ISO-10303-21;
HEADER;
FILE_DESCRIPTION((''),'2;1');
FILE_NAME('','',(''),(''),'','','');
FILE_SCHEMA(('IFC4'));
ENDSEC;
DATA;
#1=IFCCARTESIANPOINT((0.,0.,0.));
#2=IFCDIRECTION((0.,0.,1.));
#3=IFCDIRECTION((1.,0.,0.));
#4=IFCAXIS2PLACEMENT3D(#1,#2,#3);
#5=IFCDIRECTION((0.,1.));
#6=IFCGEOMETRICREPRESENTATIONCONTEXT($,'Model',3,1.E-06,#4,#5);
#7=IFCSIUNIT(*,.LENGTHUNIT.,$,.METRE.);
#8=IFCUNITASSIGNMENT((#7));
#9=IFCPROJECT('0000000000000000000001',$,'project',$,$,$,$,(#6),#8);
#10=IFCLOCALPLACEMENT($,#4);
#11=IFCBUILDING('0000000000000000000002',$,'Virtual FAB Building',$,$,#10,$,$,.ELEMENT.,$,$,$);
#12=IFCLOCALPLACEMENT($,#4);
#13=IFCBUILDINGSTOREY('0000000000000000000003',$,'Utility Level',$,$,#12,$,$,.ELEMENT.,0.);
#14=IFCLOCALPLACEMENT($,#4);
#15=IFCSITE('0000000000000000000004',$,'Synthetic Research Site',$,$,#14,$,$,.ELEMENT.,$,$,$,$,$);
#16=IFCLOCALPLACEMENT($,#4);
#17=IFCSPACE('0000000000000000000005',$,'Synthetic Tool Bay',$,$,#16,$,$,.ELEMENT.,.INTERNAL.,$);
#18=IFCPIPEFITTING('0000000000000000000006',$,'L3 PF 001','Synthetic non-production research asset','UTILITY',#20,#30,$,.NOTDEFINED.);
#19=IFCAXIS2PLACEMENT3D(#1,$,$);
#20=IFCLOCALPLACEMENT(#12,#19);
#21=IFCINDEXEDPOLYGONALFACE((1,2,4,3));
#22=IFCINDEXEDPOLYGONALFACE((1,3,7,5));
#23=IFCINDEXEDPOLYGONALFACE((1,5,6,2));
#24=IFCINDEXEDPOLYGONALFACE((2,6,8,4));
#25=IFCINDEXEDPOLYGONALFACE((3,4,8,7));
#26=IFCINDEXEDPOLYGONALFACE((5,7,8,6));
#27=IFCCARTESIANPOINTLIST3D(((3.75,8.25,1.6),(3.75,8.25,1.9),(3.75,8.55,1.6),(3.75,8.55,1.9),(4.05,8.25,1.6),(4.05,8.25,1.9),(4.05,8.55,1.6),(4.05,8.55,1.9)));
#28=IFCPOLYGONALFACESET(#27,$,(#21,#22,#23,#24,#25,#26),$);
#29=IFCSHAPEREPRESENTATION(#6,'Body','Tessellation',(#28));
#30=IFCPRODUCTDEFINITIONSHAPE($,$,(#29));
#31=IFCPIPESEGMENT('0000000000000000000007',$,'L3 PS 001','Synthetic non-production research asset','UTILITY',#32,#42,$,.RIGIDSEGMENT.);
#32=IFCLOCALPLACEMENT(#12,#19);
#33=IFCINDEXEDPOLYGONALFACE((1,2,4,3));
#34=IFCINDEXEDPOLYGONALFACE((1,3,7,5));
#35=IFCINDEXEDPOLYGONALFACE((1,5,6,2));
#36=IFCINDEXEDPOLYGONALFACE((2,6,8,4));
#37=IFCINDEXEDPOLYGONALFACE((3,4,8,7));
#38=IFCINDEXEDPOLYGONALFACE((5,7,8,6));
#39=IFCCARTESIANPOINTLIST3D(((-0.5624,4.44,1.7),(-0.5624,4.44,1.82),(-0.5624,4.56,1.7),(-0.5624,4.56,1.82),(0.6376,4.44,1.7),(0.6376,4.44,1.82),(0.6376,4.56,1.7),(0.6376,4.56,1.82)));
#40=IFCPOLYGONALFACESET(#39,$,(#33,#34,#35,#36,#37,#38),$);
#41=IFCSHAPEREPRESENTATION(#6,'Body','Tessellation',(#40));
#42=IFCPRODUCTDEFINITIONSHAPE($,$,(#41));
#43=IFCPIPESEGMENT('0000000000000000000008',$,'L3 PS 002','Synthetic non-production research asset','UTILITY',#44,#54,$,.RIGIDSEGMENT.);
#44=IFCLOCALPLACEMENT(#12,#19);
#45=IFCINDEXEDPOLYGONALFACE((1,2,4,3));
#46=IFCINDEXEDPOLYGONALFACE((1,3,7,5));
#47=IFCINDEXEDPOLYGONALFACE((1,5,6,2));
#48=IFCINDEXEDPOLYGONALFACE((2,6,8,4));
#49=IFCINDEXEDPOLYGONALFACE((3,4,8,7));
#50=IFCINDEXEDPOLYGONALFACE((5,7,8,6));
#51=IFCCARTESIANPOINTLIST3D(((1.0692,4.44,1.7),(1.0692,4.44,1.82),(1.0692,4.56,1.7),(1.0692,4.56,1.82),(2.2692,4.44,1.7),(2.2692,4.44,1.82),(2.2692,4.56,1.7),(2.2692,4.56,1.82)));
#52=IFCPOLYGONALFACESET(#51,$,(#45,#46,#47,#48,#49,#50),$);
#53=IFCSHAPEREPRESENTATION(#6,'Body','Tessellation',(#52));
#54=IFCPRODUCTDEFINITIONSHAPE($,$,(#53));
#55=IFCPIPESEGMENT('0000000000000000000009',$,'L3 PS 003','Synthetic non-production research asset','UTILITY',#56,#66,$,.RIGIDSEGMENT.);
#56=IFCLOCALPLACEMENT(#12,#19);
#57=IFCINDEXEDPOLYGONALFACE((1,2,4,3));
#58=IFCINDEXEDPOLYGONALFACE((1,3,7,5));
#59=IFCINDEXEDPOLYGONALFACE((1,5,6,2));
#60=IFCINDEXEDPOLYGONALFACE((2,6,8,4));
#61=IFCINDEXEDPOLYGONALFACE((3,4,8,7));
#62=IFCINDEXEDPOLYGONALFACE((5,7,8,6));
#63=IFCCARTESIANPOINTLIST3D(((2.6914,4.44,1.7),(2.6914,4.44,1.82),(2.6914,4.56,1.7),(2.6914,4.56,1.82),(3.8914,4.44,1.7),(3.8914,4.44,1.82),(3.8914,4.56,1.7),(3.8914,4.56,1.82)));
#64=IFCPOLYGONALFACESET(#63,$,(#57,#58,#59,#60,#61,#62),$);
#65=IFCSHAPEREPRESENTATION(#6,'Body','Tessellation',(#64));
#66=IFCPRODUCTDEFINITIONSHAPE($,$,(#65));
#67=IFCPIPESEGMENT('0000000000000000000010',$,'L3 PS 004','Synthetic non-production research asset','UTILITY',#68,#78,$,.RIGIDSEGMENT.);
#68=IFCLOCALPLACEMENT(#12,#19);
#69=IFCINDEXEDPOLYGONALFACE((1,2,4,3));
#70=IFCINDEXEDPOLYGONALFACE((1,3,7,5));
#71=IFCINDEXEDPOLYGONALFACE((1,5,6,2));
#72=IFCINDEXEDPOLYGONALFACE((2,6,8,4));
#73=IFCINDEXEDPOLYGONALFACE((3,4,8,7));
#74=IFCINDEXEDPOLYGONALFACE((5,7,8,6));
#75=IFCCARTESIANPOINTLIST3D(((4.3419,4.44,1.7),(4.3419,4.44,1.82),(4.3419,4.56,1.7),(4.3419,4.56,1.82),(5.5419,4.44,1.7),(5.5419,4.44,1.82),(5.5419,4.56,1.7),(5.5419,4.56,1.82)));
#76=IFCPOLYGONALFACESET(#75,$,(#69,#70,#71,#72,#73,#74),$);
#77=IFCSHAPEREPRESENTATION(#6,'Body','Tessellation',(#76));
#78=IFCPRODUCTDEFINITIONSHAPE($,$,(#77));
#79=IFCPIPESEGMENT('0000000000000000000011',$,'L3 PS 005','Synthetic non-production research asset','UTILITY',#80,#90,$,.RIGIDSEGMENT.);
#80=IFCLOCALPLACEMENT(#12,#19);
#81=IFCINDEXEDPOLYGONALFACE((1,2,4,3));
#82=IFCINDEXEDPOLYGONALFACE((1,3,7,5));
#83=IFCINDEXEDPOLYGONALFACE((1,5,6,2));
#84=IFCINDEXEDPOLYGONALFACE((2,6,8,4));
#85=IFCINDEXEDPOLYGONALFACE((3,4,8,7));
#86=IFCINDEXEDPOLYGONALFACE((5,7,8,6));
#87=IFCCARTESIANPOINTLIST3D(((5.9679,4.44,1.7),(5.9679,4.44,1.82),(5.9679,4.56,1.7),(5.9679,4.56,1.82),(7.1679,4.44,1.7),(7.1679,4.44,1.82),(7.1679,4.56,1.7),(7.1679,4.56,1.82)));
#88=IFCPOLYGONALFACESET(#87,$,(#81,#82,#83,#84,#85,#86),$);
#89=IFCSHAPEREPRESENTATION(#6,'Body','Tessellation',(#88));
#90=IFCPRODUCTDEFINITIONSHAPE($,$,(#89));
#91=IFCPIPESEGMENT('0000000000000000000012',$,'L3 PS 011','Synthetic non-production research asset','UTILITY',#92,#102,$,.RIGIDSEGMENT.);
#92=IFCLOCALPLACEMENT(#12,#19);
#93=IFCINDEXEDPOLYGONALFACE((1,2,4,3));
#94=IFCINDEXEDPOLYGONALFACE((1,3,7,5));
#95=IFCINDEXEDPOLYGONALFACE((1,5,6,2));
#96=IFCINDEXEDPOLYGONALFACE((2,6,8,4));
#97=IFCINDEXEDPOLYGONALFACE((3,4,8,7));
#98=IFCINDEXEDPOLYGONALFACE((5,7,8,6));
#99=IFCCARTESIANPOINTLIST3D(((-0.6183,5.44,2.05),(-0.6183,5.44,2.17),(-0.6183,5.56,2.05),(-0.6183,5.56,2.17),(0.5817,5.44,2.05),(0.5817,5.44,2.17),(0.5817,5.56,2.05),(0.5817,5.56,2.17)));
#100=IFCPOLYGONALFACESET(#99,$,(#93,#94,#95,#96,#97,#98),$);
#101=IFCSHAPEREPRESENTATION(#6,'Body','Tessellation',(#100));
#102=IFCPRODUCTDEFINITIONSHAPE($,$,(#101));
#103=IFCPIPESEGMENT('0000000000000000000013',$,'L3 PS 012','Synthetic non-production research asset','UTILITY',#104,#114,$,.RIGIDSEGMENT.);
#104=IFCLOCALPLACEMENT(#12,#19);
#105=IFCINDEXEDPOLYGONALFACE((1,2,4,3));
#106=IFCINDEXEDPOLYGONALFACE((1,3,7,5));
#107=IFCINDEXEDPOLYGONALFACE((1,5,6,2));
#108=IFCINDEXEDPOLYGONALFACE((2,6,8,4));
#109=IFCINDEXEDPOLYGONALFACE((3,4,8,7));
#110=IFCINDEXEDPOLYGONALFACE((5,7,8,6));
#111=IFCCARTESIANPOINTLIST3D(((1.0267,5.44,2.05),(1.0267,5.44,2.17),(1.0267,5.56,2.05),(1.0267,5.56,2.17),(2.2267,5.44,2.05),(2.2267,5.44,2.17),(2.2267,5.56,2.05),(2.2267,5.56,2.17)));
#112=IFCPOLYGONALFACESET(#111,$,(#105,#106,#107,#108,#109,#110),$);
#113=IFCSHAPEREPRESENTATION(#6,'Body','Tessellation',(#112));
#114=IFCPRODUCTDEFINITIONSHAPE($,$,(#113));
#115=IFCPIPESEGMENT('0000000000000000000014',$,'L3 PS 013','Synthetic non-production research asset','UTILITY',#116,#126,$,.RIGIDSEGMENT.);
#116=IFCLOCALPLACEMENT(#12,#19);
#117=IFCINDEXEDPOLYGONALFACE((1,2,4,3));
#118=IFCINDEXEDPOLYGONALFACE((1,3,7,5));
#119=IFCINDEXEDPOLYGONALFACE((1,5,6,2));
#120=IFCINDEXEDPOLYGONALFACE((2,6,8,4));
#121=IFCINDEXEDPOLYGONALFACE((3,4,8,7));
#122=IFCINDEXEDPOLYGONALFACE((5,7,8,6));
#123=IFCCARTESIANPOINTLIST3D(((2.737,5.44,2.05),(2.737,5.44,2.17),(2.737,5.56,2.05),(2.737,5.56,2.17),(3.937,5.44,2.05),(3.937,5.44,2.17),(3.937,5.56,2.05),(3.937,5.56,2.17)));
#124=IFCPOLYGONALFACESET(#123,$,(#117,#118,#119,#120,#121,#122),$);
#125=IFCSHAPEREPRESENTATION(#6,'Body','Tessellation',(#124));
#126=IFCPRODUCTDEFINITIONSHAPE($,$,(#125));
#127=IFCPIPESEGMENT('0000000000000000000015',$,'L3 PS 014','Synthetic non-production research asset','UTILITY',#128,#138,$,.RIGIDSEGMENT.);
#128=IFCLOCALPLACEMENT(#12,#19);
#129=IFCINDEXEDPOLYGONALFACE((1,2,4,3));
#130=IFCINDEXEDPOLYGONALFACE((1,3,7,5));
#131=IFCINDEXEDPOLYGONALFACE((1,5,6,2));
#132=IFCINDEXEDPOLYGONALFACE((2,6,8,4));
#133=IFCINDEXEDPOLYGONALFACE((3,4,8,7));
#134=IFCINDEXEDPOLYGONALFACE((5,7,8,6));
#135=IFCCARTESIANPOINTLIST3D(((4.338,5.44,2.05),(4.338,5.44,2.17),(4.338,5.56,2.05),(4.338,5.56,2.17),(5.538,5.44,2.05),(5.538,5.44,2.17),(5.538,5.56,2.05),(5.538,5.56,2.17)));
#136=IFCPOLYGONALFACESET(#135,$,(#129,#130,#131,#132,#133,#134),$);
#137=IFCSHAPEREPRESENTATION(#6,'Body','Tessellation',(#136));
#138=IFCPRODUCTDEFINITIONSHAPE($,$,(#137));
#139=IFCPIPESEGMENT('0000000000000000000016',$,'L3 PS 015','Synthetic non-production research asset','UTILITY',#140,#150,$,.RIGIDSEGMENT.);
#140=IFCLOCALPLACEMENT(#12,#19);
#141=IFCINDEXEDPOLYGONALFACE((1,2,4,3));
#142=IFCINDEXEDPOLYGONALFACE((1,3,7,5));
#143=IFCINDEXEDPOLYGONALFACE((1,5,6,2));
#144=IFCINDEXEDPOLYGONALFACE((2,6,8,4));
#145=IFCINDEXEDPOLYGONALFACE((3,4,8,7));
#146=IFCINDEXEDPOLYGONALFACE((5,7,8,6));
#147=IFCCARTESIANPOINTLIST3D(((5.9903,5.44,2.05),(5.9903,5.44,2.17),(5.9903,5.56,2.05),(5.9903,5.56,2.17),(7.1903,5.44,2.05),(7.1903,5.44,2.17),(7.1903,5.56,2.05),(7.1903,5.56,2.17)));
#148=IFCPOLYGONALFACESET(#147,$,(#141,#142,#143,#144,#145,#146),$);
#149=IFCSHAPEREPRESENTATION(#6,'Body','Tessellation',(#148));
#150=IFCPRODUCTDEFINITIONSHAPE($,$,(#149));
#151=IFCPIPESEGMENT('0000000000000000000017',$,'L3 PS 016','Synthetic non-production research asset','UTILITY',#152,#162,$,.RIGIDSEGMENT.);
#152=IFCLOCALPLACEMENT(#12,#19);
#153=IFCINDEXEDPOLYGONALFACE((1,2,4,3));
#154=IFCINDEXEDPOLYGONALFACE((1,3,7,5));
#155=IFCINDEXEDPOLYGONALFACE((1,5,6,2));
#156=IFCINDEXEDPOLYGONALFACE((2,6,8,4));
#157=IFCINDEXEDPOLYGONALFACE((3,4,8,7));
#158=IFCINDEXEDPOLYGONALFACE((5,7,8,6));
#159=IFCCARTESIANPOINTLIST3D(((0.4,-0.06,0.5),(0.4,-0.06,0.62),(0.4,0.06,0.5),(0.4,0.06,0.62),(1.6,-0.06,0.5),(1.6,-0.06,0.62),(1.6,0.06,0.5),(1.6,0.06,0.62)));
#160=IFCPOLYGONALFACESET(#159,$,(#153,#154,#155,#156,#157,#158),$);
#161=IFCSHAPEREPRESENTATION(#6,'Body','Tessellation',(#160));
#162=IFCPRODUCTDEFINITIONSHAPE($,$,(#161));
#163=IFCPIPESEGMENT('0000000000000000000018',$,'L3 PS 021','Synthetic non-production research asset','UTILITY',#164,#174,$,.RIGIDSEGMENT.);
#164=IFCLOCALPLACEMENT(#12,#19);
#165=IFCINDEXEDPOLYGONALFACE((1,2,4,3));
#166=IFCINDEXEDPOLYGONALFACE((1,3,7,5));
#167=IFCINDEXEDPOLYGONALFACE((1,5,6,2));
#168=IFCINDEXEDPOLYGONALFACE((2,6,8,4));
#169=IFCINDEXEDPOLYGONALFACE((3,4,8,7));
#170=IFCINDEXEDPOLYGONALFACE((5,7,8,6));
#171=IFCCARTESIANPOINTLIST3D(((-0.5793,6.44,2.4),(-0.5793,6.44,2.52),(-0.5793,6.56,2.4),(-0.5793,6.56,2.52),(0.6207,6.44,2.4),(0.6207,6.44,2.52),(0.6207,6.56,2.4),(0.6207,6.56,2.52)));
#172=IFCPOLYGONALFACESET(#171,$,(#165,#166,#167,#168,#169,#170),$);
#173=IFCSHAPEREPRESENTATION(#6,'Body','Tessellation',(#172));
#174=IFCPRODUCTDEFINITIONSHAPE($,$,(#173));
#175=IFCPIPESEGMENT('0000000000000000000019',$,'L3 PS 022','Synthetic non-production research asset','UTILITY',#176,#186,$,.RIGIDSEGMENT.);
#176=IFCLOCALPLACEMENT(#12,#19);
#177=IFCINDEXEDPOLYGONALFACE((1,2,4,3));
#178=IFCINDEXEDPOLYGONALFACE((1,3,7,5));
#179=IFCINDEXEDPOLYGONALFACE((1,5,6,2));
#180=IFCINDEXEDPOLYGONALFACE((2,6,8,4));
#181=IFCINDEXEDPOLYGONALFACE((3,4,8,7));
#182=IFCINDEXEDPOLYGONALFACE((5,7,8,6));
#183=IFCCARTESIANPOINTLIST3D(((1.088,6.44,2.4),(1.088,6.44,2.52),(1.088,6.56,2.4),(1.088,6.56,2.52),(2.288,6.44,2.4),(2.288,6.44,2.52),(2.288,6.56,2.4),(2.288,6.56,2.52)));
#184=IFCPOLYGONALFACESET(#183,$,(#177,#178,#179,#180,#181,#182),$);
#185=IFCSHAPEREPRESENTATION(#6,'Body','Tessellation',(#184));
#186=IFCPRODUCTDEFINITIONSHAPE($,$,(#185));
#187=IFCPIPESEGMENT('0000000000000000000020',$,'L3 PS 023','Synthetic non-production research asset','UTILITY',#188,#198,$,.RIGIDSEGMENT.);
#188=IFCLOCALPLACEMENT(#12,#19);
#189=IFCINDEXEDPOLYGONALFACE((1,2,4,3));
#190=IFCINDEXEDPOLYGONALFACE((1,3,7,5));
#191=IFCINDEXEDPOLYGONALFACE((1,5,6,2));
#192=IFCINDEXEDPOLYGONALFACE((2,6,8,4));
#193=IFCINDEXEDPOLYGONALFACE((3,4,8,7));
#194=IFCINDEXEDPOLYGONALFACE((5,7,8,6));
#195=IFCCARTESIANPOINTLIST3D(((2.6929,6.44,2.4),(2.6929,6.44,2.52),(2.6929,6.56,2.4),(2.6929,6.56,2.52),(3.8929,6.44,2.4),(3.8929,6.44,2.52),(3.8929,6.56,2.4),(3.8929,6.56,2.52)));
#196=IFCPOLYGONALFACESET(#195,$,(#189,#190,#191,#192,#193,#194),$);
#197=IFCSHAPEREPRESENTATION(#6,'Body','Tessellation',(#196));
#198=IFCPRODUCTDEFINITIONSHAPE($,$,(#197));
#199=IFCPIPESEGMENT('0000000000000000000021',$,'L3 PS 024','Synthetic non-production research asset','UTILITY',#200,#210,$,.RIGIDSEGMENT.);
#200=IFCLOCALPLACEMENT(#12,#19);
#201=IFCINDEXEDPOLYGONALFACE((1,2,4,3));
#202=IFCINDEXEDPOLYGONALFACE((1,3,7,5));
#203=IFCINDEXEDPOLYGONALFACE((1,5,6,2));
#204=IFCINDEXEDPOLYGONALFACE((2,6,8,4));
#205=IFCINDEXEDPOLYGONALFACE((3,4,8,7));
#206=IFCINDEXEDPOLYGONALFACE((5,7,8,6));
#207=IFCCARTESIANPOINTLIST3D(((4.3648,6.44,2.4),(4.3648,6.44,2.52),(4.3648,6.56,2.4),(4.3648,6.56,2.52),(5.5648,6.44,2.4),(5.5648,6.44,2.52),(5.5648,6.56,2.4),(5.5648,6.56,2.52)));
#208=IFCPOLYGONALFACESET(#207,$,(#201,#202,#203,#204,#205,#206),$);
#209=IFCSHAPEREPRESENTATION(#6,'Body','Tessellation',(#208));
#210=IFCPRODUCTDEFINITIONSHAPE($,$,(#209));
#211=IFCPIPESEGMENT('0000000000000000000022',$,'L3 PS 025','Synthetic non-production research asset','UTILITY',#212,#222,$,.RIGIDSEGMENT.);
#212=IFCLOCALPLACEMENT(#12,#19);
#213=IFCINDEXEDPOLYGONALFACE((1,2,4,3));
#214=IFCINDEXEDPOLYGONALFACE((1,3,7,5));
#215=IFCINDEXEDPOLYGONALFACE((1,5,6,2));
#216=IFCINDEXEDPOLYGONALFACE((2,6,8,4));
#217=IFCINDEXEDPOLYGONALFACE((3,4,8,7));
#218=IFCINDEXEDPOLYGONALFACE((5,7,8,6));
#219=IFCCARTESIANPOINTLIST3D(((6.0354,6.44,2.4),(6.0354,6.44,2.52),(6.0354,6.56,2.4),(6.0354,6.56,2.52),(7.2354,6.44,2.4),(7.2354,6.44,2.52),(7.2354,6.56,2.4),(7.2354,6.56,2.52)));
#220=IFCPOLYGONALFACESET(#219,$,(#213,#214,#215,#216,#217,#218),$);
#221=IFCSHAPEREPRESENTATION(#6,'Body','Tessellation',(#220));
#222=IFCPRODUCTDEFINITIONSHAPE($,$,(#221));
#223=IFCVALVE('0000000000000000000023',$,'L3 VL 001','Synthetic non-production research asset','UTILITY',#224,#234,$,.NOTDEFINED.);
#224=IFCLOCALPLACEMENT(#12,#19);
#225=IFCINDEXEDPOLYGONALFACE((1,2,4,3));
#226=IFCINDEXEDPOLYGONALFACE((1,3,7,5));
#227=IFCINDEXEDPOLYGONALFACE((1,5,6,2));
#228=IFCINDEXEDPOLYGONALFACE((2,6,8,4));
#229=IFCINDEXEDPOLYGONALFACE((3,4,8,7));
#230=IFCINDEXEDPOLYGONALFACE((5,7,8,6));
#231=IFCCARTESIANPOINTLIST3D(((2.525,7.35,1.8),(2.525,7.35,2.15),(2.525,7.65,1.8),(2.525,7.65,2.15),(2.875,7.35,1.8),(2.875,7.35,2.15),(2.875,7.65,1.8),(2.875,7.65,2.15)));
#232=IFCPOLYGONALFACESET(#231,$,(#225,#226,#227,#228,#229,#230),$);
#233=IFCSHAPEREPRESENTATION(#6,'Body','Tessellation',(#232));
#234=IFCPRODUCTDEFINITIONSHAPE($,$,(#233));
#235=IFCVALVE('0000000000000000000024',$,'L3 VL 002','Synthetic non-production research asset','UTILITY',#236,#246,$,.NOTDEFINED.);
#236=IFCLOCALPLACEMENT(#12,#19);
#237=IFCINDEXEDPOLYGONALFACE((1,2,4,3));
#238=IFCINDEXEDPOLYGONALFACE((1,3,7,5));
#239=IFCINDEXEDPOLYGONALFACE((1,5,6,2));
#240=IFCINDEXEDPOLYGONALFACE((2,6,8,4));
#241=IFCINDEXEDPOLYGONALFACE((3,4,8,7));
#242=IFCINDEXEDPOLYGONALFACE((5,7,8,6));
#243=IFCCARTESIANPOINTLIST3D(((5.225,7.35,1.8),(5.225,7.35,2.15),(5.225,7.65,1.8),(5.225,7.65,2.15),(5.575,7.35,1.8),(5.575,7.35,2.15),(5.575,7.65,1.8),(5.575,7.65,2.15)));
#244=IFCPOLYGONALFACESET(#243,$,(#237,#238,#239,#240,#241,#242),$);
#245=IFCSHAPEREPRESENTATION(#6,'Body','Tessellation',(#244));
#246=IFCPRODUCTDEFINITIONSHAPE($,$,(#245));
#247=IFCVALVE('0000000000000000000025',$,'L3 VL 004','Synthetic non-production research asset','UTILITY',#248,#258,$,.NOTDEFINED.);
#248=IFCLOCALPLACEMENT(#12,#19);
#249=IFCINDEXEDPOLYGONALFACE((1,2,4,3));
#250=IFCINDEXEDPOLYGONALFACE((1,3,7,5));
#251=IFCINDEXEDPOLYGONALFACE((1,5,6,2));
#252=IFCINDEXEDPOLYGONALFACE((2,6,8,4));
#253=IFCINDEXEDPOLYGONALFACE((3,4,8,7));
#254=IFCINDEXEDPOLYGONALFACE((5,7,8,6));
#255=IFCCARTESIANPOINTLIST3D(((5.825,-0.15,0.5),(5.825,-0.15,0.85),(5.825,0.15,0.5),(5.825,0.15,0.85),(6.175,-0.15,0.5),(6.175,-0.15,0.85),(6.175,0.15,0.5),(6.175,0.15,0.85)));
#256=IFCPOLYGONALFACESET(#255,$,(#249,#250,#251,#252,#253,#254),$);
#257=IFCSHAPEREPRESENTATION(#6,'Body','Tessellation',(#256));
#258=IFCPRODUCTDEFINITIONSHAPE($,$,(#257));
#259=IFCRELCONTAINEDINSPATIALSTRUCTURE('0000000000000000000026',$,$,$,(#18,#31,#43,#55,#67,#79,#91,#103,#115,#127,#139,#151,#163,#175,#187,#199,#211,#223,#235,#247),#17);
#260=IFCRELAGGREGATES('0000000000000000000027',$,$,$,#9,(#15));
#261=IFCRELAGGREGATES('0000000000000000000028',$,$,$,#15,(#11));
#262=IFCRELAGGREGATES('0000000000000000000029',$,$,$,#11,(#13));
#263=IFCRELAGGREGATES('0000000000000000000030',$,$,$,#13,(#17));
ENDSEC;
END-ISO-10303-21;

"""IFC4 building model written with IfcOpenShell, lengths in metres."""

from ifc_helpers import new_model, si_unit, direction, frame, origin_with_axes, origin_2d_with_axis, place, context, project, spatial, rectangle, extrude, element, save


model = new_model("IFC4")

# Units and contexts
model_context = context("Model", 3, precision=1e-06, world=origin_with_axes(), true_north=direction((0.0, 1.0)))
ifc_project = project(units=[si_unit("LENGTHUNIT", "METRE")], contexts=[model_context])

# Site, building, storey, space
site_placement = place(None, origin_with_axes())
site = spatial("IfcSite", under=ifc_project, at=site_placement, Name="Synthetic Research Site", CompositionType="ELEMENT")
building_placement = place(None, origin_with_axes())
building = spatial("IfcBuilding", under=site, at=building_placement, Name="Virtual FAB Building", CompositionType="ELEMENT")
storey_placement = place(None, origin_with_axes())
storey = spatial("IfcBuildingStorey", under=building, at=storey_placement, Name="Utility Level", CompositionType="ELEMENT", Elevation=0.0)
space_placement = place(None, origin_with_axes())
space = spatial("IfcSpace", under=storey, at=space_placement, Name="Synthetic Tool Bay", CompositionType="ELEMENT", PredefinedType="INTERNAL")

# Pipe fitting
pipe_fitting_placement = place(None, frame((3.9, 8.4, 1.6), z_axis=(0.0, 0.0, 1.0), x_axis=(1.0, 0.0, 0.0)))
element("IfcPipeFitting", 1, at=pipe_fitting_placement, inside=space, Name="L3 PF 001", Description="Synthetic non-production research asset", ObjectType="UTILITY", PredefinedType="NOTDEFINED", context=model_context, shape_type="SweptSolid", body=[
    extrude(rectangle(XDim=0.3, YDim=0.3, at=origin_2d_with_axis()), origin_with_axes(), (0.0, 0.0, 1.0), 0.3),
])

# Pipe segments
for number, where, z_axis, x_axis, name in (
    (2, (0.0376, 4.5, 1.7), (0.0, 0.0, 1.0), (1.0, 0.0, 0.0), "L3 PS 001"),
    (3, (1.6692, 4.5, 1.7), (0.0, 0.0, 1.0), (1.0, 0.0, 0.0), "L3 PS 002"),
    (4, (3.2914, 4.5, 1.7), (0.0, 0.0, 1.0), (1.0, 0.0, 0.0), "L3 PS 003"),
    (5, (4.9419, 4.5, 1.7), (0.0, 0.0, 1.0), (1.0, 0.0, 0.0), "L3 PS 004"),
    (6, (6.5679, 4.5, 1.7), (0.0, 0.0, 1.0), (1.0, 0.0, 0.0), "L3 PS 005"),
    (7, (-0.0183, 5.5, 2.05), (0.0, 0.0, 1.0), (1.0, 0.0, 0.0), "L3 PS 011"),
    (8, (1.6267, 5.5, 2.05), (0.0, 0.0, 1.0), (1.0, 0.0, 0.0), "L3 PS 012"),
    (9, (3.337, 5.5, 2.05), (0.0, 0.0, 1.0), (1.0, 0.0, 0.0), "L3 PS 013"),
    (10, (4.938, 5.5, 2.05), (0.0, 0.0, 1.0), (1.0, 0.0, 0.0), "L3 PS 014"),
    (11, (6.5903, 5.5, 2.05), (0.0, 0.0, 1.0), (1.0, 0.0, 0.0), "L3 PS 015"),
    (12, (1.0, 0.0, 0.5), (0.0, 0.0, 1.0), (1.0, 0.0, 0.0), "L3 PS 016"),
    (13, (0.0207, 6.5, 2.4), (0.0, 0.0, 1.0), (1.0, 0.0, 0.0), "L3 PS 021"),
    (14, (1.688, 6.5, 2.4), (0.0, 0.0, 1.0), (1.0, 0.0, 0.0), "L3 PS 022"),
    (15, (3.2929, 6.5, 2.4), (0.0, 0.0, 1.0), (1.0, 0.0, 0.0), "L3 PS 023"),
    (16, (4.9648, 6.5, 2.4), (0.0, 0.0, 1.0), (1.0, 0.0, 0.0), "L3 PS 024"),
    (17, (6.6354, 6.5, 2.4), (0.0, 0.0, 1.0), (1.0, 0.0, 0.0), "L3 PS 025"),
):
    element("IfcPipeSegment", number, at=place(None, frame(where, z_axis=z_axis, x_axis=x_axis)), inside=space, Name=name, Description="Synthetic non-production research asset", ObjectType="UTILITY", PredefinedType="RIGIDSEGMENT", context=model_context, shape_type="SweptSolid", body=[
        extrude(rectangle(XDim=1.2, YDim=0.12, at=origin_2d_with_axis()), origin_with_axes(), (0.0, 0.0, 1.0), 0.12),
    ])

# Valves
for number, where, z_axis, x_axis, name in (
    (18, (2.7, 7.5, 1.8), (0.0, 0.0, 1.0), (1.0, 0.0, 0.0), "L3 VL 001"),
    (19, (5.4, 7.5, 1.8), (0.0, 0.0, 1.0), (1.0, 0.0, 0.0), "L3 VL 002"),
    (20, (6.0, 0.0, 0.5), (0.0, 0.0, 1.0), (1.0, 0.0, 0.0), "L3 VL 004"),
):
    element("IfcValve", number, at=place(None, frame(where, z_axis=z_axis, x_axis=x_axis)), inside=space, Name=name, Description="Synthetic non-production research asset", ObjectType="UTILITY", PredefinedType="NOTDEFINED", context=model_context, shape_type="SweptSolid", body=[
        extrude(rectangle(XDim=0.35, YDim=0.3, at=origin_2d_with_axis()), origin_with_axes(), (0.0, 0.0, 1.0), 0.35),
    ])

save(model, "model.ifc")
